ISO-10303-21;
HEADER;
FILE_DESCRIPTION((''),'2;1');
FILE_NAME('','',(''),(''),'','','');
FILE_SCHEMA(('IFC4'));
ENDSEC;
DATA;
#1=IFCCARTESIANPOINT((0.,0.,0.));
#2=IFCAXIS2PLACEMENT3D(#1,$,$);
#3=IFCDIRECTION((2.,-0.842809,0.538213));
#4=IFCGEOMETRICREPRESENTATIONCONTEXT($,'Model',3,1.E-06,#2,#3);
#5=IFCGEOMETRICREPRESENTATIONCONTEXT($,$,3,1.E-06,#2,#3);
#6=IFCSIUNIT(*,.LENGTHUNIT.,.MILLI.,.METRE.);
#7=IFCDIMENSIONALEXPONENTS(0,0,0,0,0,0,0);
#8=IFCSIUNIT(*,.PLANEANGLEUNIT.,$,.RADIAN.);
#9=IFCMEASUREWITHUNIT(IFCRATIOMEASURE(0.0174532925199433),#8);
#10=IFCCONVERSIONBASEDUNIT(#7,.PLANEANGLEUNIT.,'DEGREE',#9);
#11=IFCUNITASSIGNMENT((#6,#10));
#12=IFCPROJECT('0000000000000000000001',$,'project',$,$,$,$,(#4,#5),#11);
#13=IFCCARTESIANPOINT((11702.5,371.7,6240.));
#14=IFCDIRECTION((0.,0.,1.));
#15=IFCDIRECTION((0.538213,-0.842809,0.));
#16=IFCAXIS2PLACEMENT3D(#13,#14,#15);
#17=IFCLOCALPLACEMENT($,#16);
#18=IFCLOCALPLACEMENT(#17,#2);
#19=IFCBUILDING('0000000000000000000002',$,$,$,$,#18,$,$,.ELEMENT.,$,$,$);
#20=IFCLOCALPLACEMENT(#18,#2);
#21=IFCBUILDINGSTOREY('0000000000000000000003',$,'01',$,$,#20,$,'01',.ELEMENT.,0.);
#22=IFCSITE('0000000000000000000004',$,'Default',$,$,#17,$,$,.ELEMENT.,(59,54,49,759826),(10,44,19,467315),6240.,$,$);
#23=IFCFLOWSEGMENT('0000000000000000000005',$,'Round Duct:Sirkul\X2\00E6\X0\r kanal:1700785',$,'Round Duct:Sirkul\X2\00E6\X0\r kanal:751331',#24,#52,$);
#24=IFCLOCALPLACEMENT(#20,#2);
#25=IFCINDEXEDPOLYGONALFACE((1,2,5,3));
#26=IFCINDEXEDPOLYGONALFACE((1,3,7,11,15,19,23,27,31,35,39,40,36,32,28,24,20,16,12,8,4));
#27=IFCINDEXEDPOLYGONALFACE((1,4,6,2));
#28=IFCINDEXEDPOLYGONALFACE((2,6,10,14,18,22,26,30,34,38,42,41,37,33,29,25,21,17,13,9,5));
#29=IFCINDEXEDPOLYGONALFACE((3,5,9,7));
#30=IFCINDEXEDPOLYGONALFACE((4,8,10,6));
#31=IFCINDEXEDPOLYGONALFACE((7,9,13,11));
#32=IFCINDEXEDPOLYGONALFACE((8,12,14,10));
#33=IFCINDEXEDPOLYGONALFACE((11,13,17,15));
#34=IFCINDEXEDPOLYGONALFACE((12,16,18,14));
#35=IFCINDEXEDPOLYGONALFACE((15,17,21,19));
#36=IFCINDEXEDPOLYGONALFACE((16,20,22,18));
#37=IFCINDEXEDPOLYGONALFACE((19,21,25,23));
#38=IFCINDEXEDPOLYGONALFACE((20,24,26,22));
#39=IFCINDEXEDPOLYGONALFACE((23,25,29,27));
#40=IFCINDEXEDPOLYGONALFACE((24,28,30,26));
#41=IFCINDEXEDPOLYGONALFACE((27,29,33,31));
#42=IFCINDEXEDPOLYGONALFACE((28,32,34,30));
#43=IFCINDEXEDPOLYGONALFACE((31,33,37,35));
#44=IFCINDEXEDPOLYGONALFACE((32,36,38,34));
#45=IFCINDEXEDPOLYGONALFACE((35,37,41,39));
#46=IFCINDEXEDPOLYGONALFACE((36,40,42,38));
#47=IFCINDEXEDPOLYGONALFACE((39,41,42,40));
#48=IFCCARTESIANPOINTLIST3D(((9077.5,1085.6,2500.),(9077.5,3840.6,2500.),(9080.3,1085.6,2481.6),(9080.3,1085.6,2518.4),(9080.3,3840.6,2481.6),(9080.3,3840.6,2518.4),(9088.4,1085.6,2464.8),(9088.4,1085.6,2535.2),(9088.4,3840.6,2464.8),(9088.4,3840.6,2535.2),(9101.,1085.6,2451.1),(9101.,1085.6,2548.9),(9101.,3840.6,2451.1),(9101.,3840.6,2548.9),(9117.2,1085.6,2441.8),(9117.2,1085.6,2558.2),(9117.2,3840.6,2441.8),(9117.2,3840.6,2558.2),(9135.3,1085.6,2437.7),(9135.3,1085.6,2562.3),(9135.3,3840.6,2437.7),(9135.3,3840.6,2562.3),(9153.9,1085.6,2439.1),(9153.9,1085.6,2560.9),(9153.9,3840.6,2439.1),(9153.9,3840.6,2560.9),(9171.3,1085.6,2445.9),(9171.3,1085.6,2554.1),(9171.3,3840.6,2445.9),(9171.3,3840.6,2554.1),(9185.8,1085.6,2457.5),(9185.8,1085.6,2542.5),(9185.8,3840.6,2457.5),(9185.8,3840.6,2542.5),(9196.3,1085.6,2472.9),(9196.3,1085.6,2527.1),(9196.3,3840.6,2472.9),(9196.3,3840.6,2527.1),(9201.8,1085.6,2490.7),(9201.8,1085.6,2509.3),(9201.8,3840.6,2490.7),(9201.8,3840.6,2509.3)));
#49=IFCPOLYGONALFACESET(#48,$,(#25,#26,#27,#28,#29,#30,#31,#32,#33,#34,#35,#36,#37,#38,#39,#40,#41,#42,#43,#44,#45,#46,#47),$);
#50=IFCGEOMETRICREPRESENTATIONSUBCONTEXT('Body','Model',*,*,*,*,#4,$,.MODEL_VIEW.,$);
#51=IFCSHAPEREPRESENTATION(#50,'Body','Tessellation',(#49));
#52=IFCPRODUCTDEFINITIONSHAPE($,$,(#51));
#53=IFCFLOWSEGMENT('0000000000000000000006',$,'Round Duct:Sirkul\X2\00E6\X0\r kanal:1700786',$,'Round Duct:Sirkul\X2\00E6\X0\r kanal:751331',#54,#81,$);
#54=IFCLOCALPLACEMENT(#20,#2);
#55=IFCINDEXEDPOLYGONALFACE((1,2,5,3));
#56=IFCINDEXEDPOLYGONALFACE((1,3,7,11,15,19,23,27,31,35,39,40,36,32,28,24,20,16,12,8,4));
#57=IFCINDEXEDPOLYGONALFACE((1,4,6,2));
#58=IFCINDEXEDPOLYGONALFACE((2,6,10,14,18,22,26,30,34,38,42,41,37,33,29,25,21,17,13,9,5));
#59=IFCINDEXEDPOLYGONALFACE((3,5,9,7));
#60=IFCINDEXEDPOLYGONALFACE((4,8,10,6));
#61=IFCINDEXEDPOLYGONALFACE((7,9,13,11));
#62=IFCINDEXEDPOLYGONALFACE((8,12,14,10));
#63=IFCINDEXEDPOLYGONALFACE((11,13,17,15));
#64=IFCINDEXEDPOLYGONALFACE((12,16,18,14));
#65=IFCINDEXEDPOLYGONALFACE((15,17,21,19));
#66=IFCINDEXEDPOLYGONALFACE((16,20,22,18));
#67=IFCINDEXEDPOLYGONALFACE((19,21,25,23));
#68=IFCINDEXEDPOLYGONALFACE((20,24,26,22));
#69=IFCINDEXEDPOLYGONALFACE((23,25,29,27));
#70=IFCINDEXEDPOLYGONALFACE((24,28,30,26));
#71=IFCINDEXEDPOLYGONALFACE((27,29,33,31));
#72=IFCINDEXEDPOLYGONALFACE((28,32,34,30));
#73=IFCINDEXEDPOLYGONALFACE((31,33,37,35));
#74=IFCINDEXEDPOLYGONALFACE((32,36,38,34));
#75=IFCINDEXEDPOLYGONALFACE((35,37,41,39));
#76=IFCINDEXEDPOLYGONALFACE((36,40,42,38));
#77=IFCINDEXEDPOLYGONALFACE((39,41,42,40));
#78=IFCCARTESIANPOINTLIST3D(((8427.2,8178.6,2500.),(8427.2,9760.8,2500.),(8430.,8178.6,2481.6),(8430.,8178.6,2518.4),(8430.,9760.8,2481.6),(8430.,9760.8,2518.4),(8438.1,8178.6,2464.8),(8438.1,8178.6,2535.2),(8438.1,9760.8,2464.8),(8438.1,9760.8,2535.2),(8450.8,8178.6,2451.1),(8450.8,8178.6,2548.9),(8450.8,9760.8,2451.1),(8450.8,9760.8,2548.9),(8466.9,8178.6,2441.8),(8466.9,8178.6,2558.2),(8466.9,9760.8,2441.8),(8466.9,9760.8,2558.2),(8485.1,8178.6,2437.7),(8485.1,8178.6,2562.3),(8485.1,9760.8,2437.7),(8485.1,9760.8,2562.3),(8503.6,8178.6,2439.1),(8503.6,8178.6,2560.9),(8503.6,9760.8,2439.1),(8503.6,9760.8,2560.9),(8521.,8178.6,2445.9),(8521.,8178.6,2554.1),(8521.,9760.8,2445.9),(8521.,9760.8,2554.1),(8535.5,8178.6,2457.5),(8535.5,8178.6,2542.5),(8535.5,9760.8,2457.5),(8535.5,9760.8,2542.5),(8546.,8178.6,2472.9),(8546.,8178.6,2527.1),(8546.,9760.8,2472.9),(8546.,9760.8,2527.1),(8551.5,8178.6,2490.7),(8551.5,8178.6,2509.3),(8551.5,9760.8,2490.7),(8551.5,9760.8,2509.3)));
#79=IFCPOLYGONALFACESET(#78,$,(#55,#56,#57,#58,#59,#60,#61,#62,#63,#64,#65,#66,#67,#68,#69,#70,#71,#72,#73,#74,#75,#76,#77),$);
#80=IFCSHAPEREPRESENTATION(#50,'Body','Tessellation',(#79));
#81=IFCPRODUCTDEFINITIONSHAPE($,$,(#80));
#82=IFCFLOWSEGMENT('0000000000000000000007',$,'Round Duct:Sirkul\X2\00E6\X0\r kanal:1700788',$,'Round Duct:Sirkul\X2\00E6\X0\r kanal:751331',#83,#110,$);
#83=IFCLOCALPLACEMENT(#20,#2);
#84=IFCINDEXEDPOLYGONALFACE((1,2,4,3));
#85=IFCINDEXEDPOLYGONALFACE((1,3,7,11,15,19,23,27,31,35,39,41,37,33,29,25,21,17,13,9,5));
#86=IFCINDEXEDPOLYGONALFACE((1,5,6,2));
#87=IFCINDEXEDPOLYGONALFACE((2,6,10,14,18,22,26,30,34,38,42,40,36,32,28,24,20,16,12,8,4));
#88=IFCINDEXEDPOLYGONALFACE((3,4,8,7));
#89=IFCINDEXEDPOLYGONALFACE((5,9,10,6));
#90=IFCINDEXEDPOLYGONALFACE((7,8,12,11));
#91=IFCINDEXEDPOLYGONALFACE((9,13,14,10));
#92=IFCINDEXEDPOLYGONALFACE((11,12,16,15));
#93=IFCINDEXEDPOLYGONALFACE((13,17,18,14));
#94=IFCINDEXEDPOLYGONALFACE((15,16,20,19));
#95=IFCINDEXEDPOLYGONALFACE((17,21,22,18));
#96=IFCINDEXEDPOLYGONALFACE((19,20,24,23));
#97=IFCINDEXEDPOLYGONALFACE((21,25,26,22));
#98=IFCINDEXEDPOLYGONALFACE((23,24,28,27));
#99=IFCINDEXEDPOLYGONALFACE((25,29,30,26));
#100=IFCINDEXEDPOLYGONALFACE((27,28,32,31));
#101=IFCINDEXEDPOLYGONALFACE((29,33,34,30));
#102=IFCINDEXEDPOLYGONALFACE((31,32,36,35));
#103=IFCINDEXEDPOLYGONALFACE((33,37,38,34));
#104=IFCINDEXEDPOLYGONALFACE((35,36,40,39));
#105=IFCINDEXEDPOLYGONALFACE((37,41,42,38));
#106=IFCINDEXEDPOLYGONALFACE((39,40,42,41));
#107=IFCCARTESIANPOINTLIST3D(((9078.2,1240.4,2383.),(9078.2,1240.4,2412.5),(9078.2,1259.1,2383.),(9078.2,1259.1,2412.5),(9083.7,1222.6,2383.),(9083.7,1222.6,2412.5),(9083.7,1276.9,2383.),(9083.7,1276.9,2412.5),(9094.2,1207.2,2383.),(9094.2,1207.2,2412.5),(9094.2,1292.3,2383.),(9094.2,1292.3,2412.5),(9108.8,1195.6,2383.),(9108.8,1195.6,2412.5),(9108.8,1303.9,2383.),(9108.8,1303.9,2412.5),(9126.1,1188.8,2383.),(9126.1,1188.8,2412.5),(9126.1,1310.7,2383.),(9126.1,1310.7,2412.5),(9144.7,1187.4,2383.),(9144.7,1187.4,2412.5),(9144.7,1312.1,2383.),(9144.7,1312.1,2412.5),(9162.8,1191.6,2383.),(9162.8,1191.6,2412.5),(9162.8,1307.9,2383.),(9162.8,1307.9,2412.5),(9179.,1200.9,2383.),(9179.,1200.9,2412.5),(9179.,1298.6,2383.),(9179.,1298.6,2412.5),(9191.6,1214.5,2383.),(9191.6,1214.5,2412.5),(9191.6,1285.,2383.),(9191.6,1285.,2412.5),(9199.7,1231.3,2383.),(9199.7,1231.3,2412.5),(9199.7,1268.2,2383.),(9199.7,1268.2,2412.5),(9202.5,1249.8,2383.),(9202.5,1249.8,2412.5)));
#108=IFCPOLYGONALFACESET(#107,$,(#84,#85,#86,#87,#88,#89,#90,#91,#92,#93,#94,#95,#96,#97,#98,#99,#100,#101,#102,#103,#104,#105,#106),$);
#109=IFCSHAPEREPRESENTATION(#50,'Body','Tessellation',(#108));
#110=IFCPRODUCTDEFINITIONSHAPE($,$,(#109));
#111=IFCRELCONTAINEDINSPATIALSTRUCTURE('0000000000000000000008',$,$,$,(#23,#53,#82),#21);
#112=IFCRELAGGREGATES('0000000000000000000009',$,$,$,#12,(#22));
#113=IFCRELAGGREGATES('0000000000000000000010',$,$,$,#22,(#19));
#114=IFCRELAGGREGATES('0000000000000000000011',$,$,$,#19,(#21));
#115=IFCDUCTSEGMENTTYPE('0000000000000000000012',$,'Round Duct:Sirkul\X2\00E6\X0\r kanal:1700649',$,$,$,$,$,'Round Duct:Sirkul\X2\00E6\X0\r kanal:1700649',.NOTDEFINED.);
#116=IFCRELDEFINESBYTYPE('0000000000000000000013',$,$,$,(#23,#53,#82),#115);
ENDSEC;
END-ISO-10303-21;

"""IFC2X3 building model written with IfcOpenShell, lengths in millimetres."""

from ifc_helpers import new_model, entity, si_unit, converted_unit, direction, frame, frame_2d, origin, origin_2d_with_axis, place, context, subcontext, project, spatial, circle, extrude, type_object, element, save


model = new_model("IFC2X3")

# Units and contexts
model_context = context("Model", 3, precision=1e-06, world=origin(), true_north=direction((2.0, -0.842809, 0.538213)))
context_of_model = context(None, 3, precision=1e-06, world=origin(), true_north=direction((2.0, -0.842809, 0.538213)))
body_context = subcontext(model_context, "Body", "Model", "MODEL_VIEW")
ifc_project = project(units=[si_unit("LENGTHUNIT", "METRE", prefix="MILLI"), converted_unit("PLANEANGLEUNIT", "DEGREE", entity("IfcRatioMeasure", 0.0174532925199433), si_unit("PLANEANGLEUNIT", "RADIAN"), dimensions=[0, 0, 0, 0, 0, 0, 0])], contexts=[model_context, context_of_model])

# Site, building, storey
site_placement = place(None, frame((11702.5, 371.7, 6240.0), z_axis=(0.0, 0.0, 1.0), x_axis=(0.538213, -0.842809, 0.0)))
site = spatial("IfcSite", under=ifc_project, at=site_placement, Name="Default", CompositionType="ELEMENT", RefLatitude=(59, 54, 49, 759826), RefLongitude=(10, 44, 19, 467315), RefElevation=6240.0)
building_placement = place(site_placement, origin())
building = spatial("IfcBuilding", under=site, at=building_placement, CompositionType="ELEMENT")
storey_placement = place(building_placement, origin())
storey = spatial("IfcBuildingStorey", under=building, at=storey_placement, Name="01", LongName="01", CompositionType="ELEMENT", Elevation=0.0)

# Flow segments
duct_segment_type = type_object("IfcDuctSegmentType", Name="Round Duct:Sirkulær kanal:1700649", ElementType="Round Duct:Sirkulær kanal:1700649", PredefinedType="NOTDEFINED")
flow_segment_1_placement = place(storey_placement, origin())
element("IfcFlowSegment", 1, at=flow_segment_1_placement, inside=storey, type_object=duct_segment_type, Name="Round Duct:Sirkulær kanal:1700785", ObjectType="Round Duct:Sirkulær kanal:751331", context=body_context, shape_type="SweptSolid", body=[
    extrude(circle(Radius=62.5, at=origin_2d_with_axis()), frame((9140.0, 1085.6, 2500.0), z_axis=(0.0, 1.0, 0.0), x_axis=(-1.0, 0.0, 0.0)), (0.0, 0.0, 1.0), 2755.0),
])
flow_segment_2_placement = place(storey_placement, origin())
element("IfcFlowSegment", 2, at=flow_segment_2_placement, inside=storey, type_object=duct_segment_type, Name="Round Duct:Sirkulær kanal:1700786", ObjectType="Round Duct:Sirkulær kanal:751331", context=body_context, shape_type="SweptSolid", body=[
    extrude(circle(Radius=62.5, at=frame_2d((0.0, 0.0), x_axis=(1.0, 0.0))), frame((8489.7, 8178.6, 2500.0), z_axis=(0.0, 1.0, 0.0), x_axis=(-1.0, 0.0, 0.0)), (0.0, 0.0, 1.0), 1582.2),
])
flow_segment_3_placement = place(storey_placement, origin())
element("IfcFlowSegment", 3, at=flow_segment_3_placement, inside=storey, type_object=duct_segment_type, Name="Round Duct:Sirkulær kanal:1700788", ObjectType="Round Duct:Sirkulær kanal:751331", context=body_context, shape_type="SweptSolid", body=[
    extrude(circle(Radius=62.5, at=frame_2d((0.0, 0.0), x_axis=(1.0, 0.0))), frame((9140.0, 1249.8, 2383.0)), (0.0, 0.0, 1.0), 29.5),
])

save(model, "model.ifc")
